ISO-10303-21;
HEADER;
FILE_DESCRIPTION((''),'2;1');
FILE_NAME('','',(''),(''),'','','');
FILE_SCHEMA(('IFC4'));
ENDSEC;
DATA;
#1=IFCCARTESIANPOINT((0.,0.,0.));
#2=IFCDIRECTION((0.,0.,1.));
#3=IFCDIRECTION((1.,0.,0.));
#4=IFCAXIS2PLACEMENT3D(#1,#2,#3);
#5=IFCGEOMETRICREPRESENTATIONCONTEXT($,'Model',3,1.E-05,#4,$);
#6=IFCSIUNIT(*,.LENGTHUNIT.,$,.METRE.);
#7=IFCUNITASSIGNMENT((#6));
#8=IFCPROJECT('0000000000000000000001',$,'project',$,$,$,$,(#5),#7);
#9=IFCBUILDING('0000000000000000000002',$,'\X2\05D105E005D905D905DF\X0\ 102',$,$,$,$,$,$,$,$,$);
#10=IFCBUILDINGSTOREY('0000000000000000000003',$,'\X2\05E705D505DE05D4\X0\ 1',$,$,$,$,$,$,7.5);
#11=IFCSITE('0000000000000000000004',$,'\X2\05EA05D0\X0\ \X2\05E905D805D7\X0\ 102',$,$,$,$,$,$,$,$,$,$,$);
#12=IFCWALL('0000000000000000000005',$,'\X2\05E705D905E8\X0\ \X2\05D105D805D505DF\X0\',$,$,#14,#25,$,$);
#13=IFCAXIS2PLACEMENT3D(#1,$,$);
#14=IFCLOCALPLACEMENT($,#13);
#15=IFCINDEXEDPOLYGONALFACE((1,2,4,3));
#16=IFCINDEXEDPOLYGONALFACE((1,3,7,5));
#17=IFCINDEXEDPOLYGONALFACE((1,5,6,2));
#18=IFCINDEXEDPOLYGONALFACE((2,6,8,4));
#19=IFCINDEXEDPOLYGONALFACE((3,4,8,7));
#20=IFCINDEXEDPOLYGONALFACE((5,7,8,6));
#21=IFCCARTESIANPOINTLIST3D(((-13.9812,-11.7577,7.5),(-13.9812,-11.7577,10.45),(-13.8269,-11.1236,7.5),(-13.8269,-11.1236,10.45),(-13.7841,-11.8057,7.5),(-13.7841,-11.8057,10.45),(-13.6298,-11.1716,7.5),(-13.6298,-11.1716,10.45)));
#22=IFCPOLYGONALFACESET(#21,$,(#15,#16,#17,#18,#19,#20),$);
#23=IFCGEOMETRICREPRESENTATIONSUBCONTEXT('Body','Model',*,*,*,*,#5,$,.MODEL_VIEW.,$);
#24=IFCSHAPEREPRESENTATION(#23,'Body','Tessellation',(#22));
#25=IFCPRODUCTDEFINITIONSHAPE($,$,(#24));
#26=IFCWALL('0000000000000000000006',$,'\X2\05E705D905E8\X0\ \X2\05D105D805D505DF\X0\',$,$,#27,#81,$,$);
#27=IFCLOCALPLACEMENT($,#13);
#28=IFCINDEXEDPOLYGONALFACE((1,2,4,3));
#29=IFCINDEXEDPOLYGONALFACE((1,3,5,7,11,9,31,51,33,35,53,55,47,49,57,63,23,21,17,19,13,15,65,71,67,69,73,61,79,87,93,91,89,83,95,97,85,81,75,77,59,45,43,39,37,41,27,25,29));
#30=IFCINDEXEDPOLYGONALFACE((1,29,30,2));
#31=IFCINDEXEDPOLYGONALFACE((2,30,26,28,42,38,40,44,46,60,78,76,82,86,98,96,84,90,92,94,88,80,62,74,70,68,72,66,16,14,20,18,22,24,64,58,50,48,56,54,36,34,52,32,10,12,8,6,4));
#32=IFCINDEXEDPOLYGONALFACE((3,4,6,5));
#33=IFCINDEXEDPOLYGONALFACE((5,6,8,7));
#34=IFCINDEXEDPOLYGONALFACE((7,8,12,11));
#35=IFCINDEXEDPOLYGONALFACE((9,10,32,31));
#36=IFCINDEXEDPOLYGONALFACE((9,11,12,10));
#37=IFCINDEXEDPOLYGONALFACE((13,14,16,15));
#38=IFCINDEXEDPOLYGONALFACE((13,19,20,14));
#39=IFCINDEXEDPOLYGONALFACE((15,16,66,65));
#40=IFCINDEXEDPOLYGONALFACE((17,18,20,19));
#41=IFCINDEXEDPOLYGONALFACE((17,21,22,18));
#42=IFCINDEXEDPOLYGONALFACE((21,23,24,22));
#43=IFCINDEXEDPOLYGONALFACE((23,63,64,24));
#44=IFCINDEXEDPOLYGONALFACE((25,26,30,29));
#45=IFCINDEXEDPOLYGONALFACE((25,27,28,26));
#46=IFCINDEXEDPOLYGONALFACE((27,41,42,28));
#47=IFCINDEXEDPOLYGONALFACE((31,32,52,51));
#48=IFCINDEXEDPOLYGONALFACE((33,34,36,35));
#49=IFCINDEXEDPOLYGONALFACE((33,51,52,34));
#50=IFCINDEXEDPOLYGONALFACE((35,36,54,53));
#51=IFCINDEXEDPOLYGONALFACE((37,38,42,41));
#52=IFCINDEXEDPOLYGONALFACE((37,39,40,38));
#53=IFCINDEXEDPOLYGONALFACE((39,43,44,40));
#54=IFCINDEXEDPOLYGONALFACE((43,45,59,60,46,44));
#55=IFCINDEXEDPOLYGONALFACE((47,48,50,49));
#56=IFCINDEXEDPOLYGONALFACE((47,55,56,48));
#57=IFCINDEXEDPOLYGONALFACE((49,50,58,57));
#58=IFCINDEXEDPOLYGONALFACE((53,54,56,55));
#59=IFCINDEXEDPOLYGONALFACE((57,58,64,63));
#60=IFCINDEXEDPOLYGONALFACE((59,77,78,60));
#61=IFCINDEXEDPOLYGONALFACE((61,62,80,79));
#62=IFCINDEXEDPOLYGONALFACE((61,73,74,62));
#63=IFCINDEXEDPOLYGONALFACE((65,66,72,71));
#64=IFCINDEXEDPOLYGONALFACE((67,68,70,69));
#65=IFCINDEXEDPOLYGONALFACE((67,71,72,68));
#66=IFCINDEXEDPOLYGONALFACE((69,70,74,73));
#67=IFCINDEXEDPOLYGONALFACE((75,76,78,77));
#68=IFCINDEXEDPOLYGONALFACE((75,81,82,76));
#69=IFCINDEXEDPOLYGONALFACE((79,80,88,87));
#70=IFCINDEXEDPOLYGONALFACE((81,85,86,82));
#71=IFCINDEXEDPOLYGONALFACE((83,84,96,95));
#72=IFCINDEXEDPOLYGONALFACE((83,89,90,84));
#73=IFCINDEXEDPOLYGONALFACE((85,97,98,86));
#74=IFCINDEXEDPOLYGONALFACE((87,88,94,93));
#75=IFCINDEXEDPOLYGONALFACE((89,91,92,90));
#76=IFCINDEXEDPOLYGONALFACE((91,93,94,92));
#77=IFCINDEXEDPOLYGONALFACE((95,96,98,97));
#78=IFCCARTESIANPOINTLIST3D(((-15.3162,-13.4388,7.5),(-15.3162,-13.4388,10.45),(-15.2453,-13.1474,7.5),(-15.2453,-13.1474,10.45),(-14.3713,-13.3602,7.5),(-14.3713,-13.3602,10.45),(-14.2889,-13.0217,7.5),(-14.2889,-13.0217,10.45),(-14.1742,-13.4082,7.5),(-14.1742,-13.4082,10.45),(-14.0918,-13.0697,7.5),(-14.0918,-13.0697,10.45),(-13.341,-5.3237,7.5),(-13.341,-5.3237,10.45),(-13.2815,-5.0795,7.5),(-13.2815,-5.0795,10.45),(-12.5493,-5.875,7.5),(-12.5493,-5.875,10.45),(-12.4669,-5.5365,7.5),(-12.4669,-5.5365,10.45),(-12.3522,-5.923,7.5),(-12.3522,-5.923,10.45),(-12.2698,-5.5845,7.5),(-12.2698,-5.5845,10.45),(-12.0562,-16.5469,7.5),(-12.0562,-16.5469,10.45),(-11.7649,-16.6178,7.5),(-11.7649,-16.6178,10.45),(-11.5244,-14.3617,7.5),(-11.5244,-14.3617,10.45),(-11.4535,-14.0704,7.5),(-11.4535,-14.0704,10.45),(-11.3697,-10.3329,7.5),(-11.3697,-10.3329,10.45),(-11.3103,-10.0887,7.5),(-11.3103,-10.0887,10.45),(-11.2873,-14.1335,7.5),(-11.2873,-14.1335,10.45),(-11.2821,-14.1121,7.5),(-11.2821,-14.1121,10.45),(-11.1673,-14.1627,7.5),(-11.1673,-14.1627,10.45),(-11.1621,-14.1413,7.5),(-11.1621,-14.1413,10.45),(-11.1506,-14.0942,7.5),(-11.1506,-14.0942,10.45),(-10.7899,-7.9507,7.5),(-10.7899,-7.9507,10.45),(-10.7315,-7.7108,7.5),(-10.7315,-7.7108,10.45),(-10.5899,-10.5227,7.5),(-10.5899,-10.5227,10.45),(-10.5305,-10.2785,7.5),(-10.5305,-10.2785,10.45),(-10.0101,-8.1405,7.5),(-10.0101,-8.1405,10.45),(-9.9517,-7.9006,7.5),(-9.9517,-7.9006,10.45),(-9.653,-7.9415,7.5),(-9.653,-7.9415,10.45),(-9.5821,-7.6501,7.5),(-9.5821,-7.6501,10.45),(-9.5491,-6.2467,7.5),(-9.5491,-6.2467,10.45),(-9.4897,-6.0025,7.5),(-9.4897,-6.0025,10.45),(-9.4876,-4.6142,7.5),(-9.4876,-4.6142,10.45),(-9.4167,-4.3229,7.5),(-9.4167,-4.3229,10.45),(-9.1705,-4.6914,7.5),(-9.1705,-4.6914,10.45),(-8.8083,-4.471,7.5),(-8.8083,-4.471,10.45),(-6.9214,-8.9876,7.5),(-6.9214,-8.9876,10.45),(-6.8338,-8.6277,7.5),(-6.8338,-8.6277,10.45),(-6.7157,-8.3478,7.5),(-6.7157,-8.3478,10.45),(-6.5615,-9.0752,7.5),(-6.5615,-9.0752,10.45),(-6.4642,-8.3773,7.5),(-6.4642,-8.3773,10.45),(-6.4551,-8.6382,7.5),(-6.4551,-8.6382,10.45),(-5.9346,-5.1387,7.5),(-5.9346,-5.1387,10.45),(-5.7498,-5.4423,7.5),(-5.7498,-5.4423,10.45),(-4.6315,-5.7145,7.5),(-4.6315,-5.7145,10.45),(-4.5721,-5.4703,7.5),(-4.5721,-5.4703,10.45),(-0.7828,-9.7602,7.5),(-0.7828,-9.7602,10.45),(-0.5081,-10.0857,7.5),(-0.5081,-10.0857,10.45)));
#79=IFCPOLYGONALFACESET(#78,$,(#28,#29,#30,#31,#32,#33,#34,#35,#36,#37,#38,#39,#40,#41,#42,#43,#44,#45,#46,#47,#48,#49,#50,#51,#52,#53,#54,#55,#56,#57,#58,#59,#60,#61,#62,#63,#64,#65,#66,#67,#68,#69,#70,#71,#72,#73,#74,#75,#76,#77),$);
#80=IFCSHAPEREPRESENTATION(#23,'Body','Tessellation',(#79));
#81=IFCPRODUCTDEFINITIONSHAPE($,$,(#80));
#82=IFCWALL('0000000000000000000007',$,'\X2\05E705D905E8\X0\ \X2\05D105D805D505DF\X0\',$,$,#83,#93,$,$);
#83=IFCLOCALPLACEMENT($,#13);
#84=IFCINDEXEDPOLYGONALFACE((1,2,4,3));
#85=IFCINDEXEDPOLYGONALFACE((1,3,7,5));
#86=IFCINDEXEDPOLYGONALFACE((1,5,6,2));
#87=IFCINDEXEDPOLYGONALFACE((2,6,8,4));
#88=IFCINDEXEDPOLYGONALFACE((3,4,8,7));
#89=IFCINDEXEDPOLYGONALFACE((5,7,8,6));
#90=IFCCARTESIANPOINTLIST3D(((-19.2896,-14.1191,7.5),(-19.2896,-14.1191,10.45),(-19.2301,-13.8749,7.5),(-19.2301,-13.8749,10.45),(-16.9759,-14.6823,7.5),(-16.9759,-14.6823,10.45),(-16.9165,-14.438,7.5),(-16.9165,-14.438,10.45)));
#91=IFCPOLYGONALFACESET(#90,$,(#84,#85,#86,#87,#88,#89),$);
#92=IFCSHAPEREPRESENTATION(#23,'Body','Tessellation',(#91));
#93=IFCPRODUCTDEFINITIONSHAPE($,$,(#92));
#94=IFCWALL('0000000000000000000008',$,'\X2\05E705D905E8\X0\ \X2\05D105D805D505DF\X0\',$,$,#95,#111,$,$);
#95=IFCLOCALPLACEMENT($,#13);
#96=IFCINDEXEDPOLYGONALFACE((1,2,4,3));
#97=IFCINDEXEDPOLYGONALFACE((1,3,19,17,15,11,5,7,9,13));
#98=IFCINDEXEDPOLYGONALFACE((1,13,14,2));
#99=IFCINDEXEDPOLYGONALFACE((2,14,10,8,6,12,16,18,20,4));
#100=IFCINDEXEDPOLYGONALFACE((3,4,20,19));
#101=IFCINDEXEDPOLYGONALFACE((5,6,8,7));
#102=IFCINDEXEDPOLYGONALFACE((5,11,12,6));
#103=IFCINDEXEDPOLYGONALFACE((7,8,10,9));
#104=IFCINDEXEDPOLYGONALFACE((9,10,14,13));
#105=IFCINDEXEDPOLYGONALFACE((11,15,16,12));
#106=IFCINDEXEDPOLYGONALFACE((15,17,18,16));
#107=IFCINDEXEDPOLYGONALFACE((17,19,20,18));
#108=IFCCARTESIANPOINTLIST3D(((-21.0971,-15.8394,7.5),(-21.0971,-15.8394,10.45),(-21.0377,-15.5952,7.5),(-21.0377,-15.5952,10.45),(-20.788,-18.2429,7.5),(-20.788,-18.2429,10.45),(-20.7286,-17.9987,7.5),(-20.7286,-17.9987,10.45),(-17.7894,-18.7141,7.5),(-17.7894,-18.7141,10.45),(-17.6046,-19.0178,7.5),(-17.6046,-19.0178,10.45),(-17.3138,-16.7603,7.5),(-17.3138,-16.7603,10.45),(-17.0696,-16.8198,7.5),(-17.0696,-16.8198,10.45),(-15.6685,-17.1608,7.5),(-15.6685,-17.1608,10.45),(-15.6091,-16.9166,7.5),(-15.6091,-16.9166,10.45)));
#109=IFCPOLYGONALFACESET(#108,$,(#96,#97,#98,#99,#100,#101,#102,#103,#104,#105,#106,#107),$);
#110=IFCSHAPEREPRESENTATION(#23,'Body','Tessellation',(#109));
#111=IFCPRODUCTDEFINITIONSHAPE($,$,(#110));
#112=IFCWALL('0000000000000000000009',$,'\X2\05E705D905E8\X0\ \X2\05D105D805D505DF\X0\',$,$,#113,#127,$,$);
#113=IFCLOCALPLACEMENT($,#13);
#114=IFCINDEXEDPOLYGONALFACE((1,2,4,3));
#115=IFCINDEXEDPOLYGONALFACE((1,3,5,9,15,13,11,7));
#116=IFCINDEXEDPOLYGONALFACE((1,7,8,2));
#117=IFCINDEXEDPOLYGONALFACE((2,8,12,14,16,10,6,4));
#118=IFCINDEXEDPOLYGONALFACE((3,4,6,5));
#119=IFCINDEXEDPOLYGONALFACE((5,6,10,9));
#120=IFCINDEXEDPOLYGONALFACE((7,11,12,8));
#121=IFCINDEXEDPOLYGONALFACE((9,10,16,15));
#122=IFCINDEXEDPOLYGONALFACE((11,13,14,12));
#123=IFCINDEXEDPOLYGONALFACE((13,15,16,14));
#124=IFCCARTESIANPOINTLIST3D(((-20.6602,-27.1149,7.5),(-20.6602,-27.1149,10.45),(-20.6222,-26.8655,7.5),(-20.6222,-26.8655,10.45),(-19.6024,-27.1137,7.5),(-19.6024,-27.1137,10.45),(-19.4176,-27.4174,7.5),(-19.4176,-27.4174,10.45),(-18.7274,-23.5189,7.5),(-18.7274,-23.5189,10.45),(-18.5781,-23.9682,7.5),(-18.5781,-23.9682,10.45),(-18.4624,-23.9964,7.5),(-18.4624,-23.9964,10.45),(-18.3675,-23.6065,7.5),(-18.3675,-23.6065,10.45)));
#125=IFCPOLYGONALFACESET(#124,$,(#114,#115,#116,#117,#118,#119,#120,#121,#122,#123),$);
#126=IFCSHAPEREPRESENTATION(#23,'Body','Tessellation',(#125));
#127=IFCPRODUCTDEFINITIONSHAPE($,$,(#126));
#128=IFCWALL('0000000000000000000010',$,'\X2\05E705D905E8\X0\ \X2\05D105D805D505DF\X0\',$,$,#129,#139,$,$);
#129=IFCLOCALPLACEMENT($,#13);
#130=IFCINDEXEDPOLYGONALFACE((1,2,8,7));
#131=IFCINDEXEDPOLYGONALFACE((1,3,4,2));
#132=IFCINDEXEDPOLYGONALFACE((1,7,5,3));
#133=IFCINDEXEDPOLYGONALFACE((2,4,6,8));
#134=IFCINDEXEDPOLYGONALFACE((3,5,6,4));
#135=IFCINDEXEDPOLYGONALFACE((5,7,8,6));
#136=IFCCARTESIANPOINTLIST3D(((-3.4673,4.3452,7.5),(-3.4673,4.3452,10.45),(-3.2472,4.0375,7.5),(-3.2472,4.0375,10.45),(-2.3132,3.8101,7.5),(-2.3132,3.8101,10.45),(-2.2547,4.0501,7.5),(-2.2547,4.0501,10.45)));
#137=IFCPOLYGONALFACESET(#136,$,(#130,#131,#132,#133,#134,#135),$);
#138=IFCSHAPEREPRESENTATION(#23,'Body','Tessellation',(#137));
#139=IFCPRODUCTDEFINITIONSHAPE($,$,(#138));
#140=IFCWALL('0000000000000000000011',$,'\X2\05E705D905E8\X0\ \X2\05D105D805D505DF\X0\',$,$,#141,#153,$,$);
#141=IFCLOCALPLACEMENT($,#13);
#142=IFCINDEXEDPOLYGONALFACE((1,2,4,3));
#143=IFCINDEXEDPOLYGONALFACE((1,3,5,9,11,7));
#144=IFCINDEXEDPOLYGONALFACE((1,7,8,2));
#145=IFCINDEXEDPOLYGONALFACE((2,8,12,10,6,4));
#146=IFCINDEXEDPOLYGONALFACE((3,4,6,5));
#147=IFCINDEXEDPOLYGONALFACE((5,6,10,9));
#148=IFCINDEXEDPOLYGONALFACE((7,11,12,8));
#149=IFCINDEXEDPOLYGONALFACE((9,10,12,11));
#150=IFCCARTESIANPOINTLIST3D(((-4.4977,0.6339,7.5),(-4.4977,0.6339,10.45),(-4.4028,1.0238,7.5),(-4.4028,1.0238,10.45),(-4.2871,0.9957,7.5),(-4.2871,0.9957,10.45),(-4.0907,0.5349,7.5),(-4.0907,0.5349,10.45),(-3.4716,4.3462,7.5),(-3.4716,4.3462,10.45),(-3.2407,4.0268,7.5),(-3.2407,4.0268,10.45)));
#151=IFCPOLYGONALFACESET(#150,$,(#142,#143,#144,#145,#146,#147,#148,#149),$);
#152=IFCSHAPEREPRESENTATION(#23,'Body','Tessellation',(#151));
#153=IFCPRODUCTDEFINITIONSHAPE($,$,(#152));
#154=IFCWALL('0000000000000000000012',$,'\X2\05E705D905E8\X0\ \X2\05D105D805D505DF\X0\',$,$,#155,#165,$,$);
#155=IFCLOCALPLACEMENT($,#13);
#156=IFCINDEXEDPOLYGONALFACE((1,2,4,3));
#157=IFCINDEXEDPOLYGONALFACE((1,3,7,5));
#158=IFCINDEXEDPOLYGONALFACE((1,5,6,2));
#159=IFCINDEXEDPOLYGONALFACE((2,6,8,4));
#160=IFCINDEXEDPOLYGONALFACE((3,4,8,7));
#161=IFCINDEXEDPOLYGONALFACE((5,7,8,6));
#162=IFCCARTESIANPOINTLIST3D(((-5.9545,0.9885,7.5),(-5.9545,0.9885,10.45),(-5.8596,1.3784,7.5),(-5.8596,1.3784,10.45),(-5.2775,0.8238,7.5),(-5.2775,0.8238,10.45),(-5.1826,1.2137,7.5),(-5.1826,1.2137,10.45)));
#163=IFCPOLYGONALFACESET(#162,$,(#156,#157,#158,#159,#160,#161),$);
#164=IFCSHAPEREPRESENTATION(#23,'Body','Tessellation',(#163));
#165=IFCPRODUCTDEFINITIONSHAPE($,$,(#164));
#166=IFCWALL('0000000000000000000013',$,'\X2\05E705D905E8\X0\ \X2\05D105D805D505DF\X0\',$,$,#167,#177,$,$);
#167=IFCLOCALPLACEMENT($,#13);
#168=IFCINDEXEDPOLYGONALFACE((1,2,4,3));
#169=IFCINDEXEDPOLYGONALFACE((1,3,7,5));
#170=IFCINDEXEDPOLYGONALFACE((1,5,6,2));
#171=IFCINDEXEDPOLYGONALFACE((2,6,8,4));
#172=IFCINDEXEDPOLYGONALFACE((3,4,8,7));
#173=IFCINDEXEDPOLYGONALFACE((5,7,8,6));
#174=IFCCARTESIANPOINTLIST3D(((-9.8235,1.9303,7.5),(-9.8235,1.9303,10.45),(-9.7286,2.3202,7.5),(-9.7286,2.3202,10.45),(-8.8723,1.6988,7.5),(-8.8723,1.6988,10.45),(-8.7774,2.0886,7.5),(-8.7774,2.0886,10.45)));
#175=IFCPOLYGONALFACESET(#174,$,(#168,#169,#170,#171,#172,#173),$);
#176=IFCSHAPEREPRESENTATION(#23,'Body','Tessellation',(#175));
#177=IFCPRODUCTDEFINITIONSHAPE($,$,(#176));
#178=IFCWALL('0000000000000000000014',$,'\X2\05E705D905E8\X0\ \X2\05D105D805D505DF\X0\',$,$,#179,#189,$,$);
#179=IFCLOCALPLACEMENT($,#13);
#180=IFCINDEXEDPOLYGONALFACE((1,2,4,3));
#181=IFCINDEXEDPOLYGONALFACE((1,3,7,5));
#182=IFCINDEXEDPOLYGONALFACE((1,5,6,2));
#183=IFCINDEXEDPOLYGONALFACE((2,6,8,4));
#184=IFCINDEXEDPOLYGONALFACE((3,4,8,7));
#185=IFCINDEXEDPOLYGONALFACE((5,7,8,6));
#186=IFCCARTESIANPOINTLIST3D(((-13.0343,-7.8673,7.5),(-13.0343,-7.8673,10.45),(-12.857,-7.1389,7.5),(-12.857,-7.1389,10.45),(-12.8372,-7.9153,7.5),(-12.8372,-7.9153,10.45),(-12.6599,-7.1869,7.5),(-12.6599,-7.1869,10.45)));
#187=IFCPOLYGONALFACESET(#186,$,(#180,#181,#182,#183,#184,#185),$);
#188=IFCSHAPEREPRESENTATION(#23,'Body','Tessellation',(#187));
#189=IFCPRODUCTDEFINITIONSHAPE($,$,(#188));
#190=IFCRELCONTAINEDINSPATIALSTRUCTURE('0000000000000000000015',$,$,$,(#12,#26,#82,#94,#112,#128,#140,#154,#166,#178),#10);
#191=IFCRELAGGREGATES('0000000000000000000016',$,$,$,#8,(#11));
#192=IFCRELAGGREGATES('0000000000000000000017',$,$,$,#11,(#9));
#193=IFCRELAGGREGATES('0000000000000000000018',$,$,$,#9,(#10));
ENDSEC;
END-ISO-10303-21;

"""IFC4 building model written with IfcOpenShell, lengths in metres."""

from ifc_helpers import new_model, si_unit, frame, origin_with_axes, context, subcontext, project, spatial, polyline, outline, extrude, element, save


model = new_model("IFC4")

# Units and contexts
model_context = context("Model", 3, precision=1e-05, world=origin_with_axes())
body_context = subcontext(model_context, "Body", "Model", "MODEL_VIEW")
ifc_project = project(units=[si_unit("LENGTHUNIT", "METRE")], contexts=[model_context])

# Site, building, storey
site = spatial("IfcSite", under=ifc_project, Name="תא שטח 102")
building = spatial("IfcBuilding", under=site, Name="בניין 102")
storey = spatial("IfcBuildingStorey", under=building, Name="קומה 1", Elevation=7.5)

# Walls
element("IfcWall", 1, inside=storey, Name="קיר בטון", context=body_context, shape_type="SweptSolid", body=[
    extrude(outline(polyline([(-13.8269, -11.1236), (-13.9812, -11.7577), (-13.7841, -11.8057), (-13.6298, -11.1716), (-13.8269, -11.1236)])), frame((0.0, 0.0, 7.5)), (0.0, 0.0, 1.0), 2.95),
])
element("IfcWall", 2, inside=storey, Name="קיר בטון", context=body_context, shape_type="SweptSolid", body=[
    extrude(outline(polyline([(-14.2889, -13.0217), (-14.3713, -13.3602), (-15.2453, -13.1474), (-15.3162, -13.4388), (-11.5244, -14.3617), (-12.0562, -16.5469), (-11.7649, -16.6178), (-11.1673, -14.1627), (-11.2873, -14.1335), (-11.2821, -14.1121), (-11.1621, -14.1413), (-11.1506, -14.0942), (-9.653, -7.9415), (-6.8338, -8.6277), (-6.9214, -8.9876), (-6.5615, -9.0752), (-6.4551, -8.6382), (-0.5081, -10.0857), (-0.7828, -9.7602), (-6.4642, -8.3773), (-5.7498, -5.4423), (-4.6315, -5.7145), (-4.5721, -5.4703), (-5.9346, -5.1387), (-6.7157, -8.3478), (-9.5821, -7.6501), (-8.8083, -4.471), (-9.4167, -4.3229), (-9.4876, -4.6142), (-9.1705, -4.6914), (-9.4897, -6.0025), (-13.2815, -5.0795), (-13.341, -5.3237), (-12.4669, -5.5365), (-12.5493, -5.875), (-12.3522, -5.923), (-12.2698, -5.5845), (-9.5491, -6.2467), (-9.9517, -7.9006), (-10.7315, -7.7108), (-10.7899, -7.9507), (-10.0101, -8.1405), (-10.5305, -10.2785), (-11.3103, -10.0887), (-11.3697, -10.3329), (-10.5899, -10.5227), (-11.4535, -14.0704), (-14.1742, -13.4082), (-14.0918, -13.0697), (-14.2889, -13.0217)])), frame((0.0, 0.0, 7.5)), (0.0, 0.0, 1.0), 2.95),
])
element("IfcWall", 3, inside=storey, Name="קיר בטון", context=body_context, shape_type="SweptSolid", body=[
    extrude(outline(polyline([(-16.9165, -14.438), (-19.2301, -13.8749), (-19.2896, -14.1191), (-16.9759, -14.6823), (-16.9165, -14.438)])), frame((0.0, 0.0, 7.5)), (0.0, 0.0, 1.0), 2.95),
])
element("IfcWall", 4, inside=storey, Name="קיר בטון", context=body_context, shape_type="SweptSolid", body=[
    extrude(outline(polyline([(-20.788, -18.2429), (-17.6046, -19.0178), (-17.0696, -16.8198), (-15.6685, -17.1608), (-15.6091, -16.9166), (-21.0377, -15.5952), (-21.0971, -15.8394), (-17.3138, -16.7603), (-17.7894, -18.7141), (-20.7286, -17.9987), (-20.788, -18.2429)])), frame((0.0, 0.0, 7.5)), (0.0, 0.0, 1.0), 2.95),
])
element("IfcWall", 5, inside=storey, Name="קיר בטון", context=body_context, shape_type="SweptSolid", body=[
    extrude(outline(polyline([(-19.6024, -27.1137), (-20.6222, -26.8655), (-20.6602, -27.1149), (-19.4176, -27.4174), (-18.5781, -23.9682), (-18.4624, -23.9964), (-18.3675, -23.6065), (-18.7274, -23.5189), (-19.6024, -27.1137)])), frame((0.0, 0.0, 7.5)), (0.0, 0.0, 1.0), 2.95),
])
element("IfcWall", 6, inside=storey, Name="קיר בטון", context=body_context, shape_type="SweptSolid", body=[
    extrude(outline(polyline([(-3.2472, 4.0375), (-2.3132, 3.8101), (-2.2547, 4.0501), (-3.4673, 4.3452), (-3.2472, 4.0375)])), frame((0.0, 0.0, 7.5)), (0.0, 0.0, 1.0), 2.95),
])
element("IfcWall", 7, inside=storey, Name="קיר בטון", context=body_context, shape_type="SweptSolid", body=[
    extrude(outline(polyline([(-4.4977, 0.6339), (-4.0907, 0.5349), (-3.2407, 4.0268), (-3.4716, 4.3462), (-4.2871, 0.9957), (-4.4028, 1.0238), (-4.4977, 0.6339)])), frame((0.0, 0.0, 7.5)), (0.0, 0.0, 1.0), 2.95),
])
element("IfcWall", 8, inside=storey, Name="קיר בטון", context=body_context, shape_type="SweptSolid", body=[
    extrude(outline(polyline([(-5.9545, 0.9885), (-5.2775, 0.8238), (-5.1826, 1.2137), (-5.8596, 1.3784), (-5.9545, 0.9885)])), frame((0.0, 0.0, 7.5)), (0.0, 0.0, 1.0), 2.95),
])
element("IfcWall", 9, inside=storey, Name="קיר בטון", context=body_context, shape_type="SweptSolid", body=[
    extrude(outline(polyline([(-8.8723, 1.6988), (-8.7774, 2.0886), (-9.7286, 2.3202), (-9.8235, 1.9303), (-8.8723, 1.6988)])), frame((0.0, 0.0, 7.5)), (0.0, 0.0, 1.0), 2.95),
])
element("IfcWall", 10, inside=storey, Name="קיר בטון", context=body_context, shape_type="SweptSolid", body=[
    extrude(outline(polyline([(-12.8372, -7.9153), (-12.6599, -7.1869), (-12.857, -7.1389), (-13.0343, -7.8673), (-12.8372, -7.9153)])), frame((0.0, 0.0, 7.5)), (0.0, 0.0, 1.0), 2.95),
])

save(model, "model.ifc")
